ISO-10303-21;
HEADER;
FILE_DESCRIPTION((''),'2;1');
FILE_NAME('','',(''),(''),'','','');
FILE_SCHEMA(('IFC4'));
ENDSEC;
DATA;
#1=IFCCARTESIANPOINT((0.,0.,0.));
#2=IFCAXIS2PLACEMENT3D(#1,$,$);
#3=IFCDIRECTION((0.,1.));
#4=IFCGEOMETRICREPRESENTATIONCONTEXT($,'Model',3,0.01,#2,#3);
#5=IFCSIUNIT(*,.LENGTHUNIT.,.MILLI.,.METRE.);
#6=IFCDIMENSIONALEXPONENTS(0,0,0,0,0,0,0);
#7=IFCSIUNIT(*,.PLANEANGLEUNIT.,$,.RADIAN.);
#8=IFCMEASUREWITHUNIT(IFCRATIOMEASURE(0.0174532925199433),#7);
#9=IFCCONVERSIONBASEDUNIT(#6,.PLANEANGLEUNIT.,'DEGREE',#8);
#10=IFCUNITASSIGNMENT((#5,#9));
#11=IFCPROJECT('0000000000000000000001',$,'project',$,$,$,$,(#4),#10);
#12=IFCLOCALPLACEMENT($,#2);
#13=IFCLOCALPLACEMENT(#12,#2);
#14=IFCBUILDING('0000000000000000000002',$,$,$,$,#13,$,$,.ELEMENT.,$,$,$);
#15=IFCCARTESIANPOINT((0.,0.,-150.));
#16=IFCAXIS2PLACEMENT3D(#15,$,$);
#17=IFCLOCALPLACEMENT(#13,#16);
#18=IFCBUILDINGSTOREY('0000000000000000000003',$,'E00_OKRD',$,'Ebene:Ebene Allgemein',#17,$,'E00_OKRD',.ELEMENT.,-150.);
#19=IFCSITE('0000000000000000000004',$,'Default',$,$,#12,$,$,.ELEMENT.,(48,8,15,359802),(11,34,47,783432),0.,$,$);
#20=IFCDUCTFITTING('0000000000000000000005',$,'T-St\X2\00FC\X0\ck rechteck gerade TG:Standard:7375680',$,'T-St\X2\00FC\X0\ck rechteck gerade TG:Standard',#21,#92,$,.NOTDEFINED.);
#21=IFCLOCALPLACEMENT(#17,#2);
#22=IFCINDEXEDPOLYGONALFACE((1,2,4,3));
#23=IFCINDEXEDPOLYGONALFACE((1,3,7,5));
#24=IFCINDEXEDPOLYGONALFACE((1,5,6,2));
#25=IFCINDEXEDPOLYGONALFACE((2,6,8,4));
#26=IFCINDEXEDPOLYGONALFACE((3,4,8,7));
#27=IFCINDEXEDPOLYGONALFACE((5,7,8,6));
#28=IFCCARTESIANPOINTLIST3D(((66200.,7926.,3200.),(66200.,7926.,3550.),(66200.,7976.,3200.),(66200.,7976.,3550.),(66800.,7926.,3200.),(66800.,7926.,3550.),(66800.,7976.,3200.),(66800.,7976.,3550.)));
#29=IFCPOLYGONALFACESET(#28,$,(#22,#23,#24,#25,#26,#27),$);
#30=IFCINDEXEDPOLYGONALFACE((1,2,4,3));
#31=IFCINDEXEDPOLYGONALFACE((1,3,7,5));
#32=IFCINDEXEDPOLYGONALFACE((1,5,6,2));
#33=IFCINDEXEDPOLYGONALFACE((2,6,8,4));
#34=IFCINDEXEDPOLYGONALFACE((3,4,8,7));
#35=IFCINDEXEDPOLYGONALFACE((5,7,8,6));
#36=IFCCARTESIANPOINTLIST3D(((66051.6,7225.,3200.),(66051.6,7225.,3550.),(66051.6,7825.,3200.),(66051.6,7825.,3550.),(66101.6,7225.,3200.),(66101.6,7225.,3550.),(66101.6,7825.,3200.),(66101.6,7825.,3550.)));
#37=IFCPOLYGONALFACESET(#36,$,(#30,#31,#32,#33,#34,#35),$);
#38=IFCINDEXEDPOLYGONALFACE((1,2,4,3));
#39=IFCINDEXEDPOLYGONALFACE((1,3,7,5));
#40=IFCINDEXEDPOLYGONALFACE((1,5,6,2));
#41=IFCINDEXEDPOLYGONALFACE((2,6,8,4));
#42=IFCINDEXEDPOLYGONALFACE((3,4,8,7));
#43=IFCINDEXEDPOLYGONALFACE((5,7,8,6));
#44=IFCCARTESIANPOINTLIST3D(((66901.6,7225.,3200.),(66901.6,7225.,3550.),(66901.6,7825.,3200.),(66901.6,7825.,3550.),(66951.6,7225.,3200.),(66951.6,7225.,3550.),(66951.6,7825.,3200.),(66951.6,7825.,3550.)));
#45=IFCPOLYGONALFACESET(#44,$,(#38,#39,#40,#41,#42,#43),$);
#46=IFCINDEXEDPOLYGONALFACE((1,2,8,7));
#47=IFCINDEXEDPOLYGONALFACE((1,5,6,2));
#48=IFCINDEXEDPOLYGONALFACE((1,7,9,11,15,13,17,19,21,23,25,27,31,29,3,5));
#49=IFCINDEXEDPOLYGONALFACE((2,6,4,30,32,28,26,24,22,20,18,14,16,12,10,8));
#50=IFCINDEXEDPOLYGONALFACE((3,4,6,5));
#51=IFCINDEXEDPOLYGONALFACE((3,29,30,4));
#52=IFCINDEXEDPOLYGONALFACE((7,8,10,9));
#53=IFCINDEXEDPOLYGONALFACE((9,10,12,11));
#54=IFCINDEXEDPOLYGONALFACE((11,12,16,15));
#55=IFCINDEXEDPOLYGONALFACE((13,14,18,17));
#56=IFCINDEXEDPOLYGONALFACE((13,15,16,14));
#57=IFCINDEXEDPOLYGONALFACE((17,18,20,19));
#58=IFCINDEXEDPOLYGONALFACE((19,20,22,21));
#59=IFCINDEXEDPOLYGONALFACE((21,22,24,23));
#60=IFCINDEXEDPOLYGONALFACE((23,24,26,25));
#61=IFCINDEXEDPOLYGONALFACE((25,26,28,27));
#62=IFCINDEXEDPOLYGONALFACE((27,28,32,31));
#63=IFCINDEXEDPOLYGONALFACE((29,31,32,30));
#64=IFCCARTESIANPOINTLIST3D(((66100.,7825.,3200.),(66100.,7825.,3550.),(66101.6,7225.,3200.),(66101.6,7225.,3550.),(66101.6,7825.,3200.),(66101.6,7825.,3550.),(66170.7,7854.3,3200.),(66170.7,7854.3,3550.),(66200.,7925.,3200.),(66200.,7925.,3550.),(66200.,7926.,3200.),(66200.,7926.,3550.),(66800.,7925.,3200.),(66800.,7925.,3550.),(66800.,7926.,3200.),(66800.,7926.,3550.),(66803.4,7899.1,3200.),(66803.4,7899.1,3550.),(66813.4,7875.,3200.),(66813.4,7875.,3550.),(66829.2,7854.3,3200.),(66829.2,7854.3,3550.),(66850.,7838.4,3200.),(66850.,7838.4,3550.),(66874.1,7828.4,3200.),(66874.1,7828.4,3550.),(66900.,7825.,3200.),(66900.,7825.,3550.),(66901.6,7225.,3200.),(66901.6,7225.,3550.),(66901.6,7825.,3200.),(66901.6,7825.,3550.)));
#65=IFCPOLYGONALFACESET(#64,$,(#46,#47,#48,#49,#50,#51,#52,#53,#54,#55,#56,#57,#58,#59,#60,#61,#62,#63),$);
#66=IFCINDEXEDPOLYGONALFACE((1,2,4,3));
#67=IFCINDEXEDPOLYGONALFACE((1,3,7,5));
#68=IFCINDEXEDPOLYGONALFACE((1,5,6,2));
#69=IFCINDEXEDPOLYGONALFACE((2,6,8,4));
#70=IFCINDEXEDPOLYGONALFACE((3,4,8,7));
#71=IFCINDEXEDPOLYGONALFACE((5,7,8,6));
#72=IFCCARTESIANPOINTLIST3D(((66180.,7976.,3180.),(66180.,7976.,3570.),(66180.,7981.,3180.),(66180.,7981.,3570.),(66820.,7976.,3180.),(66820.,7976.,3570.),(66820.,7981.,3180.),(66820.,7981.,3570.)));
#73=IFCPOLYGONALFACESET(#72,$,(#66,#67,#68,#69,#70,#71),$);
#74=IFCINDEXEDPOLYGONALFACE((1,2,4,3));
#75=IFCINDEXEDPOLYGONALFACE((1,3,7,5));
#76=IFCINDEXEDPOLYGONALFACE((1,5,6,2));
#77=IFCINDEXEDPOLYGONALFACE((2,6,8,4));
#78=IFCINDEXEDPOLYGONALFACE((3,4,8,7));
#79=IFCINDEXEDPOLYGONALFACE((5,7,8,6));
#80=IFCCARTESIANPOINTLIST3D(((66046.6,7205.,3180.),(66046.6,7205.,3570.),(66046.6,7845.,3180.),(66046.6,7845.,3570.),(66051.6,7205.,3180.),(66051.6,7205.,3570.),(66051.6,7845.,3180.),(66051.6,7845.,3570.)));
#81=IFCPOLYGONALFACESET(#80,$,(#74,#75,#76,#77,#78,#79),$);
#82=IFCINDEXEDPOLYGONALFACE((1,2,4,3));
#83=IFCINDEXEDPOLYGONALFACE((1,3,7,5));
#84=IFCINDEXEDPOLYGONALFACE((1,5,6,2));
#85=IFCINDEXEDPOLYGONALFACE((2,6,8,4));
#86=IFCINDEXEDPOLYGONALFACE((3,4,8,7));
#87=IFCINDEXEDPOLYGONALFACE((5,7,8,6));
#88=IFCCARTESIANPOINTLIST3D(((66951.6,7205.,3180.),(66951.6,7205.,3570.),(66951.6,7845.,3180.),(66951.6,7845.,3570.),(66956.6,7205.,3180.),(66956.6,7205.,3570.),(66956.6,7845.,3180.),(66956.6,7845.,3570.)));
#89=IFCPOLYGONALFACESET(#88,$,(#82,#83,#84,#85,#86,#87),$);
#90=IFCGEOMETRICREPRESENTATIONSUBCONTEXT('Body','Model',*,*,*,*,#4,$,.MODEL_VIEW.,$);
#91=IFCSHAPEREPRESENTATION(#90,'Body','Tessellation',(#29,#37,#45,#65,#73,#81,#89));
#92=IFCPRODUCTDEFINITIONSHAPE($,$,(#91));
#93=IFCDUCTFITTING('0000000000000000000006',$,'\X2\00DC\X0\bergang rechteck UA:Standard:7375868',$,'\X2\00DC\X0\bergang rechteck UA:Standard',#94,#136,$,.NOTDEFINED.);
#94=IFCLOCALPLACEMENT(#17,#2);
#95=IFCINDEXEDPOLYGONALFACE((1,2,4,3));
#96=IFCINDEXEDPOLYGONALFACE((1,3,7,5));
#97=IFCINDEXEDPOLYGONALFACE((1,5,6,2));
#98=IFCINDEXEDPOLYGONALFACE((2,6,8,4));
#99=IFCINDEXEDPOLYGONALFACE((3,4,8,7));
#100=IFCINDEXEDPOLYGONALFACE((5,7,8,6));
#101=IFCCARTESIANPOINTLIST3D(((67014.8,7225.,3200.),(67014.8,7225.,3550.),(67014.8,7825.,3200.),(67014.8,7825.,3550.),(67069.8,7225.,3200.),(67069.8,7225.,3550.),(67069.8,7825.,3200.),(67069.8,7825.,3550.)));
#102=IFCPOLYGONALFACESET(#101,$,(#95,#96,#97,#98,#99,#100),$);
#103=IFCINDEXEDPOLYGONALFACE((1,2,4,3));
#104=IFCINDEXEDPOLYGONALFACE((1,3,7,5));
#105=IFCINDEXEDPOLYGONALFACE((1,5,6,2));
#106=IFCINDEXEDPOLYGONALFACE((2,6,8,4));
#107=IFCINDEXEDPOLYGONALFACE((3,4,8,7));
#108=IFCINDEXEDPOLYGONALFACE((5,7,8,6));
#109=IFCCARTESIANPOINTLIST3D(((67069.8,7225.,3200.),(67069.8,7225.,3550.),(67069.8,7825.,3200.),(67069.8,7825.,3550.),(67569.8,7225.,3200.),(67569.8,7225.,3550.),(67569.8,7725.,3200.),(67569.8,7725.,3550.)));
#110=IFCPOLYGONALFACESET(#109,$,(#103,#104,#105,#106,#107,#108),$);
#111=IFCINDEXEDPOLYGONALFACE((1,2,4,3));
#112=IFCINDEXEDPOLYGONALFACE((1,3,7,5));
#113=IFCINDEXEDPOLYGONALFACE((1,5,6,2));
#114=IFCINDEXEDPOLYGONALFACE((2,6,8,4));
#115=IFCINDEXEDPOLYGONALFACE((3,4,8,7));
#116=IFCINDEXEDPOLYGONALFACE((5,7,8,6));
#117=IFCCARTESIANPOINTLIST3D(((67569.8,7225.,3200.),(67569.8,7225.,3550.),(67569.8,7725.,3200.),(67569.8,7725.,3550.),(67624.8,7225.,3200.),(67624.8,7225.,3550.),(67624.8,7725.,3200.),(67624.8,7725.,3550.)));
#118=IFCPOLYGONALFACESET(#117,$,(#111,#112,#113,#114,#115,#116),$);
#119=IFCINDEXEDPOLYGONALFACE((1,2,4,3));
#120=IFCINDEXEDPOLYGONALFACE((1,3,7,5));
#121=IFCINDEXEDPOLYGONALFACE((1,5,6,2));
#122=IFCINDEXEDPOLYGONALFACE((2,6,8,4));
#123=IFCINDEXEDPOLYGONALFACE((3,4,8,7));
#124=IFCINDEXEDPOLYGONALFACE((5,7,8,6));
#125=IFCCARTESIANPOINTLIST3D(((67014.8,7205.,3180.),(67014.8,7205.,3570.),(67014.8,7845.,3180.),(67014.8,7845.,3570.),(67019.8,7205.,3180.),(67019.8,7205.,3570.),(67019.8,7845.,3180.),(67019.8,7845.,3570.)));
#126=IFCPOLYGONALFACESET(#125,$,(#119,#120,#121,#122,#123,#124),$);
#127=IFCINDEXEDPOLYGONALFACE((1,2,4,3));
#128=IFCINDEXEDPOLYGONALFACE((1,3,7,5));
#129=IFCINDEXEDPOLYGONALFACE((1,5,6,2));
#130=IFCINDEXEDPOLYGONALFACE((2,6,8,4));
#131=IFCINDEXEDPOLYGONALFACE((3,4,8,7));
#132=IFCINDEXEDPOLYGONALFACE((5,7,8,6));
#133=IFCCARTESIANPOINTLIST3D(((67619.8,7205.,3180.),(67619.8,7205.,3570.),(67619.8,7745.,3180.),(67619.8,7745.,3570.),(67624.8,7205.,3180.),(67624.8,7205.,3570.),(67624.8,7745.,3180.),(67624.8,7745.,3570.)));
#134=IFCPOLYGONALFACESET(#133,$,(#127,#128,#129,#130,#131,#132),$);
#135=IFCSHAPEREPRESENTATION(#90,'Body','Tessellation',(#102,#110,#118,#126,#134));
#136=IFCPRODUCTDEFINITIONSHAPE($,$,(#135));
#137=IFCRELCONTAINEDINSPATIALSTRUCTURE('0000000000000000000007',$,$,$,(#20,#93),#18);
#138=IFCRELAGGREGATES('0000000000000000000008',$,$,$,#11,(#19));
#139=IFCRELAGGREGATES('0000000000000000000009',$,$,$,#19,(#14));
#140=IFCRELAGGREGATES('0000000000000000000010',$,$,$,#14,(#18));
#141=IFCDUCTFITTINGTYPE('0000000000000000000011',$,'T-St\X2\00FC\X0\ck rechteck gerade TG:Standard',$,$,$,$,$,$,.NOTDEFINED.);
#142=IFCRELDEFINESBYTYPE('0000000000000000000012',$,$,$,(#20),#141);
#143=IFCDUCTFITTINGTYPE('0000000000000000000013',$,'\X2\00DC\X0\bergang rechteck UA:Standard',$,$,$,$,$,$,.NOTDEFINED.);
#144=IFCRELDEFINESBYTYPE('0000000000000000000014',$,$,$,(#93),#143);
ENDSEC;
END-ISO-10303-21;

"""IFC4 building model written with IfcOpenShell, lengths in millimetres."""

from ifc_helpers import new_model, entity, si_unit, converted_unit, direction, frame, frame_2d, origin, origin_2d_with_axis, place, context, subcontext, project, spatial, polyline, circle_curve, parameter, trimmed, segment, composite_curve, rectangle, outline, extrude, source, transform, mapped, type_object, type_shapes, element, save


model = new_model("IFC4")

# Units and contexts
model_context = context("Model", 3, precision=0.01, world=origin(), true_north=direction((0.0, 1.0)))
body_context = subcontext(model_context, "Body", "Model", "MODEL_VIEW")
ifc_project = project(units=[si_unit("LENGTHUNIT", "METRE", prefix="MILLI"), converted_unit("PLANEANGLEUNIT", "DEGREE", entity("IfcRatioMeasure", 0.0174532925199433), si_unit("PLANEANGLEUNIT", "RADIAN"), dimensions=[0, 0, 0, 0, 0, 0, 0])], contexts=[model_context])

# Site, building, storey
site_placement = place(None, origin())
site = spatial("IfcSite", under=ifc_project, at=site_placement, Name="Default", CompositionType="ELEMENT", RefLatitude=(48, 8, 15, 359802), RefLongitude=(11, 34, 47, 783432), RefElevation=0.0)
building_placement = place(site_placement, origin())
building = spatial("IfcBuilding", under=site, at=building_placement, CompositionType="ELEMENT")
storey_placement = place(building_placement, frame((0.0, 0.0, -150.0)))
storey = spatial("IfcBuildingStorey", under=building, at=storey_placement, Name="E00_OKRD", ObjectType="Ebene:Ebene Allgemein", LongName="E00_OKRD", CompositionType="ELEMENT", Elevation=-150.0)

# Duct fittings
duct_fitting_type_1 = type_object("IfcDuctFittingType", Name="T-Stück rechteck gerade TG:Standard", PredefinedType="NOTDEFINED")
shared_shape_1 = source(origin(), body_context, "Body", "SweptSolid", [
    extrude(rectangle(XDim=50.0, YDim=600.0, at=frame_2d((0.0, 0.0), x_axis=(1.0, 0.0))), frame((0.0, -426.0, -175.0), z_axis=(0.0, 0.0, 1.0), x_axis=(0.0, -1.0, 0.0)), (0.0, 0.0, 1.0), 350.0),
    extrude(rectangle(XDim=50.0, YDim=600.0, at=frame_2d((0.0, 0.0), x_axis=(1.0, 0.0))), frame((423.4, 0.0, -175.0), z_axis=(0.0, 0.0, 1.0), x_axis=(-1.0, 0.0, 0.0)), (0.0, 0.0, 1.0), 350.0),
    extrude(rectangle(XDim=50.0, YDim=600.0, at=origin_2d_with_axis()), frame((-426.6, 0.0, -175.0)), (0.0, 0.0, 1.0), 350.0),
    extrude(outline(composite_curve([segment(trimmed(circle_curve(frame_2d((-400.6, -179.8), x_axis=(-1.0, 0.0)), 100.0), [parameter(180.0)], [parameter(270.0)], True, "PARAMETER"), False, "CONTINUOUS"), segment(polyline([(-300.6, -179.8), (-300.6, -180.8)]), True, "CONTINUOUS"), segment(polyline([(-300.6, -180.8), (299.4, -180.8)]), True, "CONTINUOUS"), segment(polyline([(299.4, -180.8), (299.4, -179.8)]), True, "CONTINUOUS"), segment(trimmed(circle_curve(frame_2d((399.4, -179.8), x_axis=(-1.0, 0.0)), 100.0), [parameter(270.0)], [parameter(0.0)], True, "PARAMETER"), False, "CONTINUOUS"), segment(polyline([(399.4, -79.8), (401.0, -79.8)]), True, "CONTINUOUS"), segment(polyline([(401.0, -79.8), (401.0, 520.2)]), True, "CONTINUOUS"), segment(polyline([(401.0, 520.2), (-399.0, 520.2)]), True, "CONTINUOUS"), segment(polyline([(-399.0, 520.2), (-399.0, -79.8)]), True, "CONTINUOUS"), segment(polyline([(-399.0, -79.8), (-400.6, -79.8)]), True, "CONTINUOUS")], self_intersect=False)), frame((-0.6, -220.2, -175.0), z_axis=(0.0, 0.0, -1.0), x_axis=(-1.0, 0.0, 0.0)), (0.0, 0.0, -1.0), 350.0),
    extrude(rectangle(XDim=5.0, YDim=640.0, at=origin_2d_with_axis()), frame((0.0, -453.5, -195.0), z_axis=(0.0, 0.0, 1.0), x_axis=(0.0, 1.0, 0.0)), (0.0, 0.0, 1.0), 390.0),
    extrude(rectangle(XDim=5.0, YDim=640.0, at=origin_2d_with_axis()), frame((450.9, 0.0, -195.0), z_axis=(0.0, 0.0, 1.0), x_axis=(-1.0, 0.0, 0.0)), (0.0, 0.0, 1.0), 390.0),
    extrude(rectangle(XDim=5.0, YDim=640.0, at=origin_2d_with_axis()), frame((-454.1, 0.0, -195.0), z_axis=(0.0, 0.0, 1.0), x_axis=(-1.0, 0.0, 0.0)), (0.0, 0.0, 1.0), 390.0),
])
type_shapes(duct_fitting_type_1, [shared_shape_1])
duct_fitting_1_placement = place(storey_placement, frame((66500.0, 7525.0, 3375.0), z_axis=(0.0, 0.0, 1.0), x_axis=(-1.0, 0.0, 0.0)))
element("IfcDuctFitting", 1, at=duct_fitting_1_placement, inside=storey, type_object=duct_fitting_type_1, Name="T-Stück rechteck gerade TG:Standard:7375680", ObjectType="T-Stück rechteck gerade TG:Standard", PredefinedType="NOTDEFINED", context=body_context, shape_type="MappedRepresentation", body=[
    mapped(shared_shape_1, transform((0.0, 0.0, 0.0), scale=1.0)),
])
duct_fitting_type_2 = type_object("IfcDuctFittingType", Name="Übergang rechteck UA:Standard", PredefinedType="NOTDEFINED")
shared_shape_2 = source(origin(), body_context, "Body", "SweptSolid", [
    extrude(rectangle(XDim=55.0, YDim=600.0, at=frame_2d((0.0, 0.0), x_axis=(1.0, 0.0))), frame((582.5, -50.0, -175.0)), (0.0, 0.0, 1.0), 350.0),
    extrude(outline(polyline([(-201.0, -269.7), (308.9, -269.7), (191.2, 318.7), (-299.1, 220.6), (-201.0, -269.7)])), frame((305.0, -25.0, -175.0), z_axis=(0.0, 0.0, 1.0), x_axis=(0.980581, -0.196116, 0.0)), (0.0, 0.0, 1.0), 350.0),
    extrude(rectangle(XDim=55.0, YDim=500.0, at=frame_2d((0.0, 0.0), x_axis=(1.0, 0.0))), frame((27.5, 0.0, -175.0)), (0.0, 0.0, 1.0), 350.0),
    extrude(rectangle(XDim=5.0, YDim=640.0, at=frame_2d((0.0, 0.0), x_axis=(1.0, 0.0))), frame((607.5, -50.0, -195.0)), (0.0, 0.0, 1.0), 390.0),
    extrude(rectangle(XDim=5.0, YDim=540.0, at=frame_2d((0.0, 0.0), x_axis=(1.0, 0.0))), frame((2.5, 0.0, -195.0)), (0.0, 0.0, 1.0), 390.0),
])
type_shapes(duct_fitting_type_2, [shared_shape_2])
duct_fitting_2_placement = place(storey_placement, frame((67624.8, 7475.0, 3375.0), z_axis=(0.0, 0.0, 1.0), x_axis=(-1.0, 0.0, 0.0)))
element("IfcDuctFitting", 2, at=duct_fitting_2_placement, inside=storey, type_object=duct_fitting_type_2, Name="Übergang rechteck UA:Standard:7375868", ObjectType="Übergang rechteck UA:Standard", PredefinedType="NOTDEFINED", context=body_context, shape_type="MappedRepresentation", body=[
    mapped(shared_shape_2, transform((0.0, 0.0, 0.0), scale=1.0)),
])

save(model, "model.ifc")
